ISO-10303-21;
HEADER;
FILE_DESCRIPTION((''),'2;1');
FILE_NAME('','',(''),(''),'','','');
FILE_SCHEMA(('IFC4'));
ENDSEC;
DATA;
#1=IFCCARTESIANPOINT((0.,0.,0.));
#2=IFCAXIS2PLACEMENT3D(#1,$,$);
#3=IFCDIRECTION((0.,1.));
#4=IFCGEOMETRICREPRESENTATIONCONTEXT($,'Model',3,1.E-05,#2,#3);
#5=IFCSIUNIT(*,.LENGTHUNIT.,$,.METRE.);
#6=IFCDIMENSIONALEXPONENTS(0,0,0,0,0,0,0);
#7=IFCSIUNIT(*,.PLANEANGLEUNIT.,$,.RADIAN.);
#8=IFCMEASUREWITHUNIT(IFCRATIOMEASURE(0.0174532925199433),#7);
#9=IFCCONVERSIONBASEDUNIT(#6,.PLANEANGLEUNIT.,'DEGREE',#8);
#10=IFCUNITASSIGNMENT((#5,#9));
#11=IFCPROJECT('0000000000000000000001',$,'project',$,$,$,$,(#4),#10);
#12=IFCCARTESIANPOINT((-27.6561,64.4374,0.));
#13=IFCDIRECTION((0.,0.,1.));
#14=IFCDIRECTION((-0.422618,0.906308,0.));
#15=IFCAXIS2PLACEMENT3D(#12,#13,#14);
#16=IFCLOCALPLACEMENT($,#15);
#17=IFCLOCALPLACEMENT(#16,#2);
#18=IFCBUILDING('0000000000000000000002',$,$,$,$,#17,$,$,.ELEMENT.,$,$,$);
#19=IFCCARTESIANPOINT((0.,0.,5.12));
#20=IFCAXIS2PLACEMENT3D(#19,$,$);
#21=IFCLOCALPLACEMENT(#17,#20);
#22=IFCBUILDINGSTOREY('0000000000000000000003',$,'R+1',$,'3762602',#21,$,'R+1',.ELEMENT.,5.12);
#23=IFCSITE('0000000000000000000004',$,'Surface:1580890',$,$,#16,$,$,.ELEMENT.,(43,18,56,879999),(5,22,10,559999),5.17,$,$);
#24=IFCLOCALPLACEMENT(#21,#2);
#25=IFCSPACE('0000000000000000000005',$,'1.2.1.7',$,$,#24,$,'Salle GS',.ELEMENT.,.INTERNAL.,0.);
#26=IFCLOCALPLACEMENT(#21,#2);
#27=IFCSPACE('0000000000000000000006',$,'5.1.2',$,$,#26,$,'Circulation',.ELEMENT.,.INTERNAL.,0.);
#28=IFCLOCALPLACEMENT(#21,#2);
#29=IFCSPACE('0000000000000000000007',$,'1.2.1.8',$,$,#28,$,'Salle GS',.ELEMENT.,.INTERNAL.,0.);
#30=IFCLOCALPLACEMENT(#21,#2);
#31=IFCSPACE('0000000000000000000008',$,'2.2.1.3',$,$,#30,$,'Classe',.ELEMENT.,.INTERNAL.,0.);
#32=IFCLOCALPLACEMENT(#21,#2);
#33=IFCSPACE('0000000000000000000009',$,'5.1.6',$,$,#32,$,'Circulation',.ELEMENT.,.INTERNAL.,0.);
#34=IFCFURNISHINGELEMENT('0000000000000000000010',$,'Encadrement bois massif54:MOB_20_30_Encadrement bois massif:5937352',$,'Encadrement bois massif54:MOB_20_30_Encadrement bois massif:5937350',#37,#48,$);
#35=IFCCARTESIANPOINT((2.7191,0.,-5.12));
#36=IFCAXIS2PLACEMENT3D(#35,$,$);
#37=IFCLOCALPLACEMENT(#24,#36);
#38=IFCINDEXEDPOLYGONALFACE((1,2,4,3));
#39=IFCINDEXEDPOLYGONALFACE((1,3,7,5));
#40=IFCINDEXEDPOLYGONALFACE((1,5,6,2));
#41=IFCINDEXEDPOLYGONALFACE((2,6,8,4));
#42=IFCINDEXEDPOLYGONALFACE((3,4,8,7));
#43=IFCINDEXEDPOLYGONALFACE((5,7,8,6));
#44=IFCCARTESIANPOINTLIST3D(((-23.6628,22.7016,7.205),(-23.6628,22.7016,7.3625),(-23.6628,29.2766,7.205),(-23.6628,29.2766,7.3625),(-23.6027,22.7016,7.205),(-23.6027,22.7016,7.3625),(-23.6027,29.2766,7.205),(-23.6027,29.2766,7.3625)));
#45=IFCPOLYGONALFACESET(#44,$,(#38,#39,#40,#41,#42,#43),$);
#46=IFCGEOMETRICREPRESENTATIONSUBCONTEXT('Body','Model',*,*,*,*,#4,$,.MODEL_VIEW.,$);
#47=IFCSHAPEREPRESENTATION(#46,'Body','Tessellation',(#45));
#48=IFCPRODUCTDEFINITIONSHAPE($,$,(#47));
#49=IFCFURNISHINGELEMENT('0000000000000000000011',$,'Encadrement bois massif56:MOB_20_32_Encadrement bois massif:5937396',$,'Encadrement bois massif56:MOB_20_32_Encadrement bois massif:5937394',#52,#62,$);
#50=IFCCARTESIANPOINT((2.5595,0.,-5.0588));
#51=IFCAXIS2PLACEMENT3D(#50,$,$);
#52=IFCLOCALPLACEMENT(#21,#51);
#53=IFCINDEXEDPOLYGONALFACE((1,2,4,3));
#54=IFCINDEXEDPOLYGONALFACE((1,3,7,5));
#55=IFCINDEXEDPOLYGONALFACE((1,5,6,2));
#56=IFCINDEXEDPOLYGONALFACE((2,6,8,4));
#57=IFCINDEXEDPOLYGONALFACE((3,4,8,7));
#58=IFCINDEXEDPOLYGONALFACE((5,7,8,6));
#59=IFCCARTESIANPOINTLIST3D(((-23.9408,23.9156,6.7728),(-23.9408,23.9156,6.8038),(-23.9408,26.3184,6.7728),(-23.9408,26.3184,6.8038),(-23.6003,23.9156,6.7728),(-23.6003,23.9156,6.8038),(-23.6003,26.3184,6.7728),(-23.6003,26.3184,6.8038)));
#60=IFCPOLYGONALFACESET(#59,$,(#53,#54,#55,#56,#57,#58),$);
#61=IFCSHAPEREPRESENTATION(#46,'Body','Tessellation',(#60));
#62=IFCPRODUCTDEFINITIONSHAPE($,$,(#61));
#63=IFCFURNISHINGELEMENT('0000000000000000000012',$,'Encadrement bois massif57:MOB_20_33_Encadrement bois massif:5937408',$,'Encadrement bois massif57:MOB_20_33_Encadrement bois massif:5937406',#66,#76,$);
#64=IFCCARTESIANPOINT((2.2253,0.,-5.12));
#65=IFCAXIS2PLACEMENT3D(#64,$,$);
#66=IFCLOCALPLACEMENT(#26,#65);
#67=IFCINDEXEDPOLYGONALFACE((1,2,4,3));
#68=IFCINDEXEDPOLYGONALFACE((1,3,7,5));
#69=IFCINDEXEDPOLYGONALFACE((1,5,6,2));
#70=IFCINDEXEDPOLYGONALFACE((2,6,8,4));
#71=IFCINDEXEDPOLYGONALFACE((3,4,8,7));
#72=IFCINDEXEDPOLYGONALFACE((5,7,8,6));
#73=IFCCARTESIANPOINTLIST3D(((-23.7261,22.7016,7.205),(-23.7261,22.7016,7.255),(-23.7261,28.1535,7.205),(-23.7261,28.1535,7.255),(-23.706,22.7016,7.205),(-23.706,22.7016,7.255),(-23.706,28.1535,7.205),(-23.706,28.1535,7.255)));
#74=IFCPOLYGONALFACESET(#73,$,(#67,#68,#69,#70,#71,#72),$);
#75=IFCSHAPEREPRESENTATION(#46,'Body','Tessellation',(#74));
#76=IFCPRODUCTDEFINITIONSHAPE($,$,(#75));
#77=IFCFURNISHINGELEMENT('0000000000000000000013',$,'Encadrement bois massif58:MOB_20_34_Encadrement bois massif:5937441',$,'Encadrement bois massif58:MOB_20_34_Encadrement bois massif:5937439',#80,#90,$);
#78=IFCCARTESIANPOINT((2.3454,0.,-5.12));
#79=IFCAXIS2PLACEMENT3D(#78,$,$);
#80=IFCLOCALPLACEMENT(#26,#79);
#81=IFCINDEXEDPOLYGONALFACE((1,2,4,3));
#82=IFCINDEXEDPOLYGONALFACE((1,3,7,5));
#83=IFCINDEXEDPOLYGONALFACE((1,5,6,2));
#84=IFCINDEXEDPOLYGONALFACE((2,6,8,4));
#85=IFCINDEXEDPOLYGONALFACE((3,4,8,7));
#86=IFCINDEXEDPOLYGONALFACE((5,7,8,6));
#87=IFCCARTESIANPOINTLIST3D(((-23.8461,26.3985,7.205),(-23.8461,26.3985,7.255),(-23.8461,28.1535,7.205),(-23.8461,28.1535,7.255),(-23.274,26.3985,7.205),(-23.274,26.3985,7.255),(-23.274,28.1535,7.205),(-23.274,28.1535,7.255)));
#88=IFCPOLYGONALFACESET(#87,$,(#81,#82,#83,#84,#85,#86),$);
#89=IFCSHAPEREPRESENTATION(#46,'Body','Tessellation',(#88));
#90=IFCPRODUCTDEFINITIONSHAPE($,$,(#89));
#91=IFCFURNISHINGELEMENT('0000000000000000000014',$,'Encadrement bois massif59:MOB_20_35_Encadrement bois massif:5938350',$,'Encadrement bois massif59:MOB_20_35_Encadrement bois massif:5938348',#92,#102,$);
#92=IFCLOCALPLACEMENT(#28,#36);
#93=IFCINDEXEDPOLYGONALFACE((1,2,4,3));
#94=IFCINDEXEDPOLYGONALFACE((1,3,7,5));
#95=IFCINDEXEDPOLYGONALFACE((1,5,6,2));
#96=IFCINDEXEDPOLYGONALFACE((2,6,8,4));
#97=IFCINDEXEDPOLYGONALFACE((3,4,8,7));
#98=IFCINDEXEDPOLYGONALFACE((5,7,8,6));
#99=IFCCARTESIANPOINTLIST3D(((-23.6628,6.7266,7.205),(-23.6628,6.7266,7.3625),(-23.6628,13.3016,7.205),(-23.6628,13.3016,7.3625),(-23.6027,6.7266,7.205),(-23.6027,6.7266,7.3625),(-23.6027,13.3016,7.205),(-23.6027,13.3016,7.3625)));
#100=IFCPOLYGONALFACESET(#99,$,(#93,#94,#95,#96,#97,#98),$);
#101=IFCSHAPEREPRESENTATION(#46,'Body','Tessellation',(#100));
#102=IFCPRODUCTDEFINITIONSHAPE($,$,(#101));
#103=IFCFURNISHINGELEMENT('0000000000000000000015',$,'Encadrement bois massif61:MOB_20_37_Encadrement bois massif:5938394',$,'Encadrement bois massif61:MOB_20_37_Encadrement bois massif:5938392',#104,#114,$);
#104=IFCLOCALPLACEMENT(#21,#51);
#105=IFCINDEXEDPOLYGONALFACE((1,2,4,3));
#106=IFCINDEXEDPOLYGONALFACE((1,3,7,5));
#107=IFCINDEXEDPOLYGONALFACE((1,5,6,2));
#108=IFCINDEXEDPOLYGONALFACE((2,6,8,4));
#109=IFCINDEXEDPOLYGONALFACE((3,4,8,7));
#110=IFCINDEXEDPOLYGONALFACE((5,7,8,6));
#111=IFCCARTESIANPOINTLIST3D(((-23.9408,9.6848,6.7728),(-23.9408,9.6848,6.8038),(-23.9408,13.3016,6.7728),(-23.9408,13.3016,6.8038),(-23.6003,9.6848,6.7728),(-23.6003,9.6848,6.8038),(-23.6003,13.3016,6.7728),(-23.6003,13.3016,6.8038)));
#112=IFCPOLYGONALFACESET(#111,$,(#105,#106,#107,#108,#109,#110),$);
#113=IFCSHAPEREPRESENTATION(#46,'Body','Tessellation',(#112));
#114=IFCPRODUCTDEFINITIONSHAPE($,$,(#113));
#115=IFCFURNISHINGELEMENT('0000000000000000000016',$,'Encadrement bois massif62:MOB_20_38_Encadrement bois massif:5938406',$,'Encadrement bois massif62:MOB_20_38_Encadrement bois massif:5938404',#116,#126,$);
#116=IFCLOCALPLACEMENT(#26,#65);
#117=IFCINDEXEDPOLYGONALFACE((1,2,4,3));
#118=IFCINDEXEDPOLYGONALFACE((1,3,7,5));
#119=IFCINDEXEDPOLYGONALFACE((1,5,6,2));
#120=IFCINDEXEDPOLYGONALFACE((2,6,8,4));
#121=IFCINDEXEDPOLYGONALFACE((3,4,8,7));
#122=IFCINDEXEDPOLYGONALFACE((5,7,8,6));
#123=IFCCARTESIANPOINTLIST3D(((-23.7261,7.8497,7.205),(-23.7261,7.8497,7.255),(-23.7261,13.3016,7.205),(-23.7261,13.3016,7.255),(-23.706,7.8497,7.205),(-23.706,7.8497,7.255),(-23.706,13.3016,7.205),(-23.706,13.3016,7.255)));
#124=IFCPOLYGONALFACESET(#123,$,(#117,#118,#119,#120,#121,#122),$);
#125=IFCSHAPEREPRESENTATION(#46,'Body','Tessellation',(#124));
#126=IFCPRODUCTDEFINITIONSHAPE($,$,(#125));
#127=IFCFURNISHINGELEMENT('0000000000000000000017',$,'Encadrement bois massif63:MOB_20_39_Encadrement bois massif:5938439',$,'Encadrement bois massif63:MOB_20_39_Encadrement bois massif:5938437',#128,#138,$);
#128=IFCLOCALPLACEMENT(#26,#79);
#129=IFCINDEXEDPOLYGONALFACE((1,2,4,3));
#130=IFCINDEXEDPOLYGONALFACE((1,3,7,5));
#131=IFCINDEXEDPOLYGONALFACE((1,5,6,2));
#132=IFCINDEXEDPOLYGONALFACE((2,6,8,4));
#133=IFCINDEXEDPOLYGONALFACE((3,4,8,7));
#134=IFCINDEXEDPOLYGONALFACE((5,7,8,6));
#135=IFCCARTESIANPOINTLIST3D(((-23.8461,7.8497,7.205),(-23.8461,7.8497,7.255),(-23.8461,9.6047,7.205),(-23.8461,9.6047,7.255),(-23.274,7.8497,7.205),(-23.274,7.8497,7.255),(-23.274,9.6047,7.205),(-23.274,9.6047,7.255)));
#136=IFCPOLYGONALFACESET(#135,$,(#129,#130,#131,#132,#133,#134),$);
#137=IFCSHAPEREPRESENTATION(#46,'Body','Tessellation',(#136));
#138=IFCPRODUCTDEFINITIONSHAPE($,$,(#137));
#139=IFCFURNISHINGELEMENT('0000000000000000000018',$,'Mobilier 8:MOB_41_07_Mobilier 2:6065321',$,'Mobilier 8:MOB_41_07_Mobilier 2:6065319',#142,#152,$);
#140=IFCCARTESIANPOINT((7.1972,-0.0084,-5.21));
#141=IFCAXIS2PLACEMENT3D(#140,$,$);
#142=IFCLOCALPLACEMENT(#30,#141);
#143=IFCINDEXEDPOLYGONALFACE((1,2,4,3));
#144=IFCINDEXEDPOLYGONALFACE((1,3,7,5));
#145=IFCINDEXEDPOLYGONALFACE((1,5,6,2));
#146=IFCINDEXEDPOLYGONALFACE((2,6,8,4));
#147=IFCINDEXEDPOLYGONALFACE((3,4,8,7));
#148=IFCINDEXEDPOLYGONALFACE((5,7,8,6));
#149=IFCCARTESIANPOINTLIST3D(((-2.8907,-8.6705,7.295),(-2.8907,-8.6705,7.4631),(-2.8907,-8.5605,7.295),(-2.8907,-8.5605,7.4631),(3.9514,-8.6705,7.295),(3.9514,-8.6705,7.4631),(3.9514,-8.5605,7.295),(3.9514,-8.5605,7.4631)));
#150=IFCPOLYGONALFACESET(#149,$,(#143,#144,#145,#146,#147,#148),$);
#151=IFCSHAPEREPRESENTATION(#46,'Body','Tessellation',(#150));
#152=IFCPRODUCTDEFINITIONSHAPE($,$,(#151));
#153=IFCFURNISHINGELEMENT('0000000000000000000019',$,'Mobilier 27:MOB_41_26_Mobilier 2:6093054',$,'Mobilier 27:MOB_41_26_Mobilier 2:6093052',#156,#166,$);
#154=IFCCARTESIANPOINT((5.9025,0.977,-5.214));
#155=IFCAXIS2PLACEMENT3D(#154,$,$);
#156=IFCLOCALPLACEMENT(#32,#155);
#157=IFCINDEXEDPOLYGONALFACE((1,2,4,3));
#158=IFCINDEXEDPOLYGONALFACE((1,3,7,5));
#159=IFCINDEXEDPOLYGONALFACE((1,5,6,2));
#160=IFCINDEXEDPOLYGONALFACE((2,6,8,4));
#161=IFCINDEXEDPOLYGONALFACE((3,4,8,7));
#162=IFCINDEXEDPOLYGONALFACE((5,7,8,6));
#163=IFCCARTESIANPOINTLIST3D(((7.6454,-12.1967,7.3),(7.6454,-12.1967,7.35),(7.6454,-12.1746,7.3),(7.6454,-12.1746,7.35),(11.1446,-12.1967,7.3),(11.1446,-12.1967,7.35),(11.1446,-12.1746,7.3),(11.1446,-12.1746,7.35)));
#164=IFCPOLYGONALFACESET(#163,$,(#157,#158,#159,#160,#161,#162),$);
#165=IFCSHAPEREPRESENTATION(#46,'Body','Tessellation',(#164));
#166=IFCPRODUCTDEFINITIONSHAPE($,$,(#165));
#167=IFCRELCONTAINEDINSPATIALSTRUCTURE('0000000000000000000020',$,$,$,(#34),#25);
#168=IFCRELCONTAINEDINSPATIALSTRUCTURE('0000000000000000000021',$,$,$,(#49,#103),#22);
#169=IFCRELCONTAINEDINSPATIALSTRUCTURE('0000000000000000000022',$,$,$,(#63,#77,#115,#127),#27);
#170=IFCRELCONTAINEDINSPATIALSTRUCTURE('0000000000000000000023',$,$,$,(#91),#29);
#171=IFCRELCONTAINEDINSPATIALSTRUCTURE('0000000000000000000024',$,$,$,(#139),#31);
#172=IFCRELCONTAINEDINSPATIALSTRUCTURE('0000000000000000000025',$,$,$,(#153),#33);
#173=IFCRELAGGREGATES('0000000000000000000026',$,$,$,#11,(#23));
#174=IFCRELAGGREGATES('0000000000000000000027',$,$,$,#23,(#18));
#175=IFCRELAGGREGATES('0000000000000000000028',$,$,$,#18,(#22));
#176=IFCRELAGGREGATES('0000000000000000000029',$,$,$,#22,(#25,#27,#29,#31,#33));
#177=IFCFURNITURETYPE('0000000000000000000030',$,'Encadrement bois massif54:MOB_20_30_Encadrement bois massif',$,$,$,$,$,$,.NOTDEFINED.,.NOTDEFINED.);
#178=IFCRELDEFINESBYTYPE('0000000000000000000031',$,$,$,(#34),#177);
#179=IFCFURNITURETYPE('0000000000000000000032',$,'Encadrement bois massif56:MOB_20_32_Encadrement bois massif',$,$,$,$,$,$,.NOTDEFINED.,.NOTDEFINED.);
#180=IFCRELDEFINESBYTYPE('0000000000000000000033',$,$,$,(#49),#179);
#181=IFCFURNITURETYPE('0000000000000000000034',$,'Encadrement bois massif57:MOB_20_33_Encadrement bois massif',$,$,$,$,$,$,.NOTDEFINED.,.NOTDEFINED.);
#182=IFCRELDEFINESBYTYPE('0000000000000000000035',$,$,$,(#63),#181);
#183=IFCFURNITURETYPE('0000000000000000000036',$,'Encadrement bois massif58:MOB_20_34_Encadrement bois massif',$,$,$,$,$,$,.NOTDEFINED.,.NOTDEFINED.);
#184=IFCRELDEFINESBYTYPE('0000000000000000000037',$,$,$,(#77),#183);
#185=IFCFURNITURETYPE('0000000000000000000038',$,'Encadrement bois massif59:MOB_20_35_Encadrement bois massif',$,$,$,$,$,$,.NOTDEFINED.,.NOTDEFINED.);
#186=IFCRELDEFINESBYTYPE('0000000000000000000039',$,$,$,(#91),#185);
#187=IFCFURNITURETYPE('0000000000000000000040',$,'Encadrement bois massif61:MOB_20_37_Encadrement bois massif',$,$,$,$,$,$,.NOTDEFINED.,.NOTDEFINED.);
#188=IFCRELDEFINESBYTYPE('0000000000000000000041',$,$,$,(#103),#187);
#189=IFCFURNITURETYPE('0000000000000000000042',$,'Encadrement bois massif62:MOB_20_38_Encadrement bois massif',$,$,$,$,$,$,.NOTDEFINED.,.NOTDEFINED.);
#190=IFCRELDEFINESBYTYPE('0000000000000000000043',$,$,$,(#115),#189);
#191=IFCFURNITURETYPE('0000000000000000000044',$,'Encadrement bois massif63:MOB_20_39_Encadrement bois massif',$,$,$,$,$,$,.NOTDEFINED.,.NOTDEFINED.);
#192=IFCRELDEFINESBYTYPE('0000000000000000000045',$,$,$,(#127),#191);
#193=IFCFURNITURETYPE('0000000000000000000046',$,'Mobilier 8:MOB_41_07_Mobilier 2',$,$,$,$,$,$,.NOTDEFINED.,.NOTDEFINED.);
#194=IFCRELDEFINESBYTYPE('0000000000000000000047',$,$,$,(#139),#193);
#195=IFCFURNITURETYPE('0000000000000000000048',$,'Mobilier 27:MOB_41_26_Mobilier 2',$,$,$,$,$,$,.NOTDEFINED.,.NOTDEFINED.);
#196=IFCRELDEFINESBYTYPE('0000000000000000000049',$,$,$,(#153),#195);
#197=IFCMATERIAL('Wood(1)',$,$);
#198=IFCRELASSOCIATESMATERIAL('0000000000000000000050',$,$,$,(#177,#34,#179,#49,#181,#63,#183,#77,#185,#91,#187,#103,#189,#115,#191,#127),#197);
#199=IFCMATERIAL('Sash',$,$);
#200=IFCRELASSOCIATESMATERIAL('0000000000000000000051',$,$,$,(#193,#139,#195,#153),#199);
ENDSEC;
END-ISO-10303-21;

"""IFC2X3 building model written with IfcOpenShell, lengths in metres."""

from ifc_helpers import new_model, entity, si_unit, converted_unit, direction, frame, frame_2d, origin, origin_2d_with_axis, place, context, subcontext, project, spatial, rectangle, extrude, source, transform, mapped, material, type_object, type_shapes, element, save


model = new_model("IFC2X3")

# Units and contexts
model_context = context("Model", 3, precision=1e-05, world=origin(), true_north=direction((0.0, 1.0)))
body_context = subcontext(model_context, "Body", "Model", "MODEL_VIEW")
ifc_project = project(units=[si_unit("LENGTHUNIT", "METRE"), converted_unit("PLANEANGLEUNIT", "DEGREE", entity("IfcRatioMeasure", 0.0174532925199433), si_unit("PLANEANGLEUNIT", "RADIAN"), dimensions=[0, 0, 0, 0, 0, 0, 0])], contexts=[model_context])

# Site, building, storey
site_placement = place(None, frame((-27.6561, 64.4374, 0.0), z_axis=(0.0, 0.0, 1.0), x_axis=(-0.422618, 0.906308, 0.0)))
site = spatial("IfcSite", under=ifc_project, at=site_placement, Name="Surface:1580890", CompositionType="ELEMENT", RefLatitude=(43, 18, 56, 879999), RefLongitude=(5, 22, 10, 559999), RefElevation=5.17)
building_placement = place(site_placement, origin())
building = spatial("IfcBuilding", under=site, at=building_placement, CompositionType="ELEMENT")
storey_placement = place(building_placement, frame((0.0, 0.0, 5.12)))
storey = spatial("IfcBuildingStorey", under=building, at=storey_placement, Name="R+1", ObjectType="3762602", LongName="R+1", CompositionType="ELEMENT", Elevation=5.12)

# Shared definitions
space_1_placement = place(storey_placement, origin())
space_1 = spatial("IfcSpace", under=storey, at=space_1_placement, Name="1.2.1.7", LongName="Salle GS", CompositionType="ELEMENT", InteriorOrExteriorSpace="INTERNAL", ElevationWithFlooring=0.0)

# Furnishing elements
ifc_material_1 = material(Name="Wood(1)")
furniture_type_1 = type_object("IfcFurnitureType", Name="Encadrement bois massif54:MOB_20_30_Encadrement bois massif", material=ifc_material_1)
shared_shape_1 = source(origin(), body_context, "Body", "SweptSolid", [
    extrude(rectangle(XDim=0.0601, YDim=6.575, at=origin_2d_with_axis()), frame((-23.6328, 25.9891, 7.205)), (0.0, 0.0, 1.0), 0.1575),
])
type_shapes(furniture_type_1, [shared_shape_1])
furnishing_1_placement = place(space_1_placement, frame((2.7191, 0.0, -5.12)))
element("IfcFurnishingElement", 1, at=furnishing_1_placement, inside=space_1, type_object=furniture_type_1, material=ifc_material_1, Name="Encadrement bois massif54:MOB_20_30_Encadrement bois massif:5937352", ObjectType="Encadrement bois massif54:MOB_20_30_Encadrement bois massif:5937350", context=body_context, shape_type="MappedRepresentation", body=[
    mapped(shared_shape_1, transform((0.0, 0.0, 0.0), scale=1.0)),
])
furniture_type_2 = type_object("IfcFurnitureType", Name="Encadrement bois massif56:MOB_20_32_Encadrement bois massif", material=ifc_material_1)
shared_shape_2 = source(origin(), body_context, "Body", "SweptSolid", [
    extrude(rectangle(XDim=0.3405, YDim=2.4028, at=frame_2d((0.0, 0.0), x_axis=(1.0, 0.0))), frame((-23.7706, 25.117, 6.7728)), (0.0, 0.0, 1.0), 0.031),
])
type_shapes(furniture_type_2, [shared_shape_2])
furnishing_2_placement = place(storey_placement, frame((2.5595, 0.0, -5.0588)))
element("IfcFurnishingElement", 2, at=furnishing_2_placement, inside=storey, type_object=furniture_type_2, material=ifc_material_1, Name="Encadrement bois massif56:MOB_20_32_Encadrement bois massif:5937396", ObjectType="Encadrement bois massif56:MOB_20_32_Encadrement bois massif:5937394", context=body_context, shape_type="MappedRepresentation", body=[
    mapped(shared_shape_2, transform((0.0, 0.0, 0.0), scale=1.0)),
])

# Shared definitions
space_2_placement = place(storey_placement, origin())
space_2 = spatial("IfcSpace", under=storey, at=space_2_placement, Name="5.1.2", LongName="Circulation", CompositionType="ELEMENT", InteriorOrExteriorSpace="INTERNAL", ElevationWithFlooring=0.0)

# Furnishing elements
furniture_type_3 = type_object("IfcFurnitureType", Name="Encadrement bois massif57:MOB_20_33_Encadrement bois massif", material=ifc_material_1)
shared_shape_3 = source(origin(), body_context, "Body", "SweptSolid", [
    extrude(rectangle(XDim=0.0201, YDim=5.4519, at=frame_2d((0.0, 0.0), x_axis=(1.0, 0.0))), frame((-23.7161, 25.4275, 7.205)), (0.0, 0.0, 1.0), 0.05),
])
type_shapes(furniture_type_3, [shared_shape_3])
furnishing_3_placement = place(space_2_placement, frame((2.2253, 0.0, -5.12)))
element("IfcFurnishingElement", 3, at=furnishing_3_placement, inside=space_2, type_object=furniture_type_3, material=ifc_material_1, Name="Encadrement bois massif57:MOB_20_33_Encadrement bois massif:5937408", ObjectType="Encadrement bois massif57:MOB_20_33_Encadrement bois massif:5937406", context=body_context, shape_type="MappedRepresentation", body=[
    mapped(shared_shape_3, transform((0.0, 0.0, 0.0), scale=1.0)),
])
furniture_type_4 = type_object("IfcFurnitureType", Name="Encadrement bois massif58:MOB_20_34_Encadrement bois massif", material=ifc_material_1)
shared_shape_4 = source(origin(), body_context, "Body", "SweptSolid", [
    extrude(rectangle(XDim=0.5721, YDim=1.755, at=frame_2d((0.0, 0.0), x_axis=(1.0, 0.0))), frame((-23.5601, 27.276, 7.205)), (0.0, 0.0, 1.0), 0.05),
])
type_shapes(furniture_type_4, [shared_shape_4])
furnishing_4_placement = place(space_2_placement, frame((2.3454, 0.0, -5.12)))
element("IfcFurnishingElement", 4, at=furnishing_4_placement, inside=space_2, type_object=furniture_type_4, material=ifc_material_1, Name="Encadrement bois massif58:MOB_20_34_Encadrement bois massif:5937441", ObjectType="Encadrement bois massif58:MOB_20_34_Encadrement bois massif:5937439", context=body_context, shape_type="MappedRepresentation", body=[
    mapped(shared_shape_4, transform((0.0, 0.0, 0.0), scale=1.0)),
])

# Shared definitions
space_3_placement = place(storey_placement, origin())
space_3 = spatial("IfcSpace", under=storey, at=space_3_placement, Name="1.2.1.8", LongName="Salle GS", CompositionType="ELEMENT", InteriorOrExteriorSpace="INTERNAL", ElevationWithFlooring=0.0)

# Furnishing elements
furniture_type_5 = type_object("IfcFurnitureType", Name="Encadrement bois massif59:MOB_20_35_Encadrement bois massif", material=ifc_material_1)
shared_shape_5 = source(origin(), body_context, "Body", "SweptSolid", [
    extrude(rectangle(XDim=6.575, YDim=0.0601, at=frame_2d((0.0, 0.0), x_axis=(1.0, 0.0))), frame((-23.6328, 10.0141, 7.205), z_axis=(0.0, 0.0, 1.0), x_axis=(0.0, -1.0, 0.0)), (0.0, 0.0, 1.0), 0.1575),
])
type_shapes(furniture_type_5, [shared_shape_5])
furnishing_5_placement = place(space_3_placement, frame((2.7191, 0.0, -5.12)))
element("IfcFurnishingElement", 5, at=furnishing_5_placement, inside=space_3, type_object=furniture_type_5, material=ifc_material_1, Name="Encadrement bois massif59:MOB_20_35_Encadrement bois massif:5938350", ObjectType="Encadrement bois massif59:MOB_20_35_Encadrement bois massif:5938348", context=body_context, shape_type="MappedRepresentation", body=[
    mapped(shared_shape_5, transform((0.0, 0.0, 0.0), scale=1.0)),
])
furniture_type_6 = type_object("IfcFurnitureType", Name="Encadrement bois massif61:MOB_20_37_Encadrement bois massif", material=ifc_material_1)
shared_shape_6 = source(origin(), body_context, "Body", "SweptSolid", [
    extrude(rectangle(XDim=3.6168, YDim=0.3405, at=frame_2d((0.0, 0.0), x_axis=(1.0, 0.0))), frame((-23.7706, 11.4932, 6.7728), z_axis=(0.0, 0.0, 1.0), x_axis=(0.0, -1.0, 0.0)), (0.0, 0.0, 1.0), 0.031),
])
type_shapes(furniture_type_6, [shared_shape_6])
furnishing_6_placement = place(storey_placement, frame((2.5595, 0.0, -5.0588)))
element("IfcFurnishingElement", 6, at=furnishing_6_placement, inside=storey, type_object=furniture_type_6, material=ifc_material_1, Name="Encadrement bois massif61:MOB_20_37_Encadrement bois massif:5938394", ObjectType="Encadrement bois massif61:MOB_20_37_Encadrement bois massif:5938392", context=body_context, shape_type="MappedRepresentation", body=[
    mapped(shared_shape_6, transform((0.0, 0.0, 0.0), scale=1.0)),
])
furniture_type_7 = type_object("IfcFurnitureType", Name="Encadrement bois massif62:MOB_20_38_Encadrement bois massif", material=ifc_material_1)
shared_shape_7 = source(origin(), body_context, "Body", "SweptSolid", [
    extrude(rectangle(XDim=5.4519, YDim=0.0201, at=frame_2d((0.0, 0.0), x_axis=(1.0, 0.0))), frame((-23.7161, 10.5757, 7.205), z_axis=(0.0, 0.0, 1.0), x_axis=(0.0, -1.0, 0.0)), (0.0, 0.0, 1.0), 0.05),
])
type_shapes(furniture_type_7, [shared_shape_7])
furnishing_7_placement = place(space_2_placement, frame((2.2253, 0.0, -5.12)))
element("IfcFurnishingElement", 7, at=furnishing_7_placement, inside=space_2, type_object=furniture_type_7, material=ifc_material_1, Name="Encadrement bois massif62:MOB_20_38_Encadrement bois massif:5938406", ObjectType="Encadrement bois massif62:MOB_20_38_Encadrement bois massif:5938404", context=body_context, shape_type="MappedRepresentation", body=[
    mapped(shared_shape_7, transform((0.0, 0.0, 0.0), scale=1.0)),
])
furniture_type_8 = type_object("IfcFurnitureType", Name="Encadrement bois massif63:MOB_20_39_Encadrement bois massif", material=ifc_material_1)
shared_shape_8 = source(origin(), body_context, "Body", "SweptSolid", [
    extrude(rectangle(XDim=1.755, YDim=0.5721, at=frame_2d((0.0, 0.0), x_axis=(1.0, 0.0))), frame((-23.5601, 8.7272, 7.205), z_axis=(0.0, 0.0, 1.0), x_axis=(0.0, -1.0, 0.0)), (0.0, 0.0, 1.0), 0.05),
])
type_shapes(furniture_type_8, [shared_shape_8])
furnishing_8_placement = place(space_2_placement, frame((2.3454, 0.0, -5.12)))
element("IfcFurnishingElement", 8, at=furnishing_8_placement, inside=space_2, type_object=furniture_type_8, material=ifc_material_1, Name="Encadrement bois massif63:MOB_20_39_Encadrement bois massif:5938439", ObjectType="Encadrement bois massif63:MOB_20_39_Encadrement bois massif:5938437", context=body_context, shape_type="MappedRepresentation", body=[
    mapped(shared_shape_8, transform((0.0, 0.0, 0.0), scale=1.0)),
])

# Shared definitions
space_4_placement = place(storey_placement, origin())
space_4 = spatial("IfcSpace", under=storey, at=space_4_placement, Name="2.2.1.3", LongName="Classe", CompositionType="ELEMENT", InteriorOrExteriorSpace="INTERNAL", ElevationWithFlooring=0.0)

# Furnishing element
ifc_material_2 = material(Name="Sash")
furniture_type_9 = type_object("IfcFurnitureType", Name="Mobilier 8:MOB_41_07_Mobilier 2", material=ifc_material_2)
shared_shape_9 = source(origin(), body_context, "Body", "SweptSolid", [
    extrude(rectangle(XDim=6.8421, YDim=0.11, at=frame_2d((0.0, 0.0), x_axis=(1.0, 0.0))), frame((0.5304, -8.6155, 7.295)), (0.0, 0.0, 1.0), 0.1681),
])
type_shapes(furniture_type_9, [shared_shape_9])
furnishing_9_placement = place(space_4_placement, frame((7.1972, -0.0084, -5.21)))
element("IfcFurnishingElement", 9, at=furnishing_9_placement, inside=space_4, type_object=furniture_type_9, material=ifc_material_2, Name="Mobilier 8:MOB_41_07_Mobilier 2:6065321", ObjectType="Mobilier 8:MOB_41_07_Mobilier 2:6065319", context=body_context, shape_type="MappedRepresentation", body=[
    mapped(shared_shape_9, transform((0.0, 0.0, 0.0), scale=1.0)),
])

# Shared definitions
space_5_placement = place(storey_placement, origin())
space_5 = spatial("IfcSpace", under=storey, at=space_5_placement, Name="5.1.6", LongName="Circulation", CompositionType="ELEMENT", InteriorOrExteriorSpace="INTERNAL", ElevationWithFlooring=0.0)

# Furnishing element
furniture_type_10 = type_object("IfcFurnitureType", Name="Mobilier 27:MOB_41_26_Mobilier 2", material=ifc_material_2)
shared_shape_10 = source(origin(), body_context, "Body", "SweptSolid", [
    extrude(rectangle(XDim=0.0222, YDim=3.4993, at=frame_2d((0.0, 0.0), x_axis=(1.0, 0.0))), frame((9.395, -12.1857, 7.3), z_axis=(0.0, 0.0, 1.0), x_axis=(0.0, -1.0, 0.0)), (0.0, 0.0, 1.0), 0.05),
])
type_shapes(furniture_type_10, [shared_shape_10])
furnishing_10_placement = place(space_5_placement, frame((5.9025, 0.977, -5.214)))
element("IfcFurnishingElement", 10, at=furnishing_10_placement, inside=space_5, type_object=furniture_type_10, material=ifc_material_2, Name="Mobilier 27:MOB_41_26_Mobilier 2:6093054", ObjectType="Mobilier 27:MOB_41_26_Mobilier 2:6093052", context=body_context, shape_type="MappedRepresentation", body=[
    mapped(shared_shape_10, transform((0.0, 0.0, 0.0), scale=1.0)),
])

save(model, "model.ifc")
